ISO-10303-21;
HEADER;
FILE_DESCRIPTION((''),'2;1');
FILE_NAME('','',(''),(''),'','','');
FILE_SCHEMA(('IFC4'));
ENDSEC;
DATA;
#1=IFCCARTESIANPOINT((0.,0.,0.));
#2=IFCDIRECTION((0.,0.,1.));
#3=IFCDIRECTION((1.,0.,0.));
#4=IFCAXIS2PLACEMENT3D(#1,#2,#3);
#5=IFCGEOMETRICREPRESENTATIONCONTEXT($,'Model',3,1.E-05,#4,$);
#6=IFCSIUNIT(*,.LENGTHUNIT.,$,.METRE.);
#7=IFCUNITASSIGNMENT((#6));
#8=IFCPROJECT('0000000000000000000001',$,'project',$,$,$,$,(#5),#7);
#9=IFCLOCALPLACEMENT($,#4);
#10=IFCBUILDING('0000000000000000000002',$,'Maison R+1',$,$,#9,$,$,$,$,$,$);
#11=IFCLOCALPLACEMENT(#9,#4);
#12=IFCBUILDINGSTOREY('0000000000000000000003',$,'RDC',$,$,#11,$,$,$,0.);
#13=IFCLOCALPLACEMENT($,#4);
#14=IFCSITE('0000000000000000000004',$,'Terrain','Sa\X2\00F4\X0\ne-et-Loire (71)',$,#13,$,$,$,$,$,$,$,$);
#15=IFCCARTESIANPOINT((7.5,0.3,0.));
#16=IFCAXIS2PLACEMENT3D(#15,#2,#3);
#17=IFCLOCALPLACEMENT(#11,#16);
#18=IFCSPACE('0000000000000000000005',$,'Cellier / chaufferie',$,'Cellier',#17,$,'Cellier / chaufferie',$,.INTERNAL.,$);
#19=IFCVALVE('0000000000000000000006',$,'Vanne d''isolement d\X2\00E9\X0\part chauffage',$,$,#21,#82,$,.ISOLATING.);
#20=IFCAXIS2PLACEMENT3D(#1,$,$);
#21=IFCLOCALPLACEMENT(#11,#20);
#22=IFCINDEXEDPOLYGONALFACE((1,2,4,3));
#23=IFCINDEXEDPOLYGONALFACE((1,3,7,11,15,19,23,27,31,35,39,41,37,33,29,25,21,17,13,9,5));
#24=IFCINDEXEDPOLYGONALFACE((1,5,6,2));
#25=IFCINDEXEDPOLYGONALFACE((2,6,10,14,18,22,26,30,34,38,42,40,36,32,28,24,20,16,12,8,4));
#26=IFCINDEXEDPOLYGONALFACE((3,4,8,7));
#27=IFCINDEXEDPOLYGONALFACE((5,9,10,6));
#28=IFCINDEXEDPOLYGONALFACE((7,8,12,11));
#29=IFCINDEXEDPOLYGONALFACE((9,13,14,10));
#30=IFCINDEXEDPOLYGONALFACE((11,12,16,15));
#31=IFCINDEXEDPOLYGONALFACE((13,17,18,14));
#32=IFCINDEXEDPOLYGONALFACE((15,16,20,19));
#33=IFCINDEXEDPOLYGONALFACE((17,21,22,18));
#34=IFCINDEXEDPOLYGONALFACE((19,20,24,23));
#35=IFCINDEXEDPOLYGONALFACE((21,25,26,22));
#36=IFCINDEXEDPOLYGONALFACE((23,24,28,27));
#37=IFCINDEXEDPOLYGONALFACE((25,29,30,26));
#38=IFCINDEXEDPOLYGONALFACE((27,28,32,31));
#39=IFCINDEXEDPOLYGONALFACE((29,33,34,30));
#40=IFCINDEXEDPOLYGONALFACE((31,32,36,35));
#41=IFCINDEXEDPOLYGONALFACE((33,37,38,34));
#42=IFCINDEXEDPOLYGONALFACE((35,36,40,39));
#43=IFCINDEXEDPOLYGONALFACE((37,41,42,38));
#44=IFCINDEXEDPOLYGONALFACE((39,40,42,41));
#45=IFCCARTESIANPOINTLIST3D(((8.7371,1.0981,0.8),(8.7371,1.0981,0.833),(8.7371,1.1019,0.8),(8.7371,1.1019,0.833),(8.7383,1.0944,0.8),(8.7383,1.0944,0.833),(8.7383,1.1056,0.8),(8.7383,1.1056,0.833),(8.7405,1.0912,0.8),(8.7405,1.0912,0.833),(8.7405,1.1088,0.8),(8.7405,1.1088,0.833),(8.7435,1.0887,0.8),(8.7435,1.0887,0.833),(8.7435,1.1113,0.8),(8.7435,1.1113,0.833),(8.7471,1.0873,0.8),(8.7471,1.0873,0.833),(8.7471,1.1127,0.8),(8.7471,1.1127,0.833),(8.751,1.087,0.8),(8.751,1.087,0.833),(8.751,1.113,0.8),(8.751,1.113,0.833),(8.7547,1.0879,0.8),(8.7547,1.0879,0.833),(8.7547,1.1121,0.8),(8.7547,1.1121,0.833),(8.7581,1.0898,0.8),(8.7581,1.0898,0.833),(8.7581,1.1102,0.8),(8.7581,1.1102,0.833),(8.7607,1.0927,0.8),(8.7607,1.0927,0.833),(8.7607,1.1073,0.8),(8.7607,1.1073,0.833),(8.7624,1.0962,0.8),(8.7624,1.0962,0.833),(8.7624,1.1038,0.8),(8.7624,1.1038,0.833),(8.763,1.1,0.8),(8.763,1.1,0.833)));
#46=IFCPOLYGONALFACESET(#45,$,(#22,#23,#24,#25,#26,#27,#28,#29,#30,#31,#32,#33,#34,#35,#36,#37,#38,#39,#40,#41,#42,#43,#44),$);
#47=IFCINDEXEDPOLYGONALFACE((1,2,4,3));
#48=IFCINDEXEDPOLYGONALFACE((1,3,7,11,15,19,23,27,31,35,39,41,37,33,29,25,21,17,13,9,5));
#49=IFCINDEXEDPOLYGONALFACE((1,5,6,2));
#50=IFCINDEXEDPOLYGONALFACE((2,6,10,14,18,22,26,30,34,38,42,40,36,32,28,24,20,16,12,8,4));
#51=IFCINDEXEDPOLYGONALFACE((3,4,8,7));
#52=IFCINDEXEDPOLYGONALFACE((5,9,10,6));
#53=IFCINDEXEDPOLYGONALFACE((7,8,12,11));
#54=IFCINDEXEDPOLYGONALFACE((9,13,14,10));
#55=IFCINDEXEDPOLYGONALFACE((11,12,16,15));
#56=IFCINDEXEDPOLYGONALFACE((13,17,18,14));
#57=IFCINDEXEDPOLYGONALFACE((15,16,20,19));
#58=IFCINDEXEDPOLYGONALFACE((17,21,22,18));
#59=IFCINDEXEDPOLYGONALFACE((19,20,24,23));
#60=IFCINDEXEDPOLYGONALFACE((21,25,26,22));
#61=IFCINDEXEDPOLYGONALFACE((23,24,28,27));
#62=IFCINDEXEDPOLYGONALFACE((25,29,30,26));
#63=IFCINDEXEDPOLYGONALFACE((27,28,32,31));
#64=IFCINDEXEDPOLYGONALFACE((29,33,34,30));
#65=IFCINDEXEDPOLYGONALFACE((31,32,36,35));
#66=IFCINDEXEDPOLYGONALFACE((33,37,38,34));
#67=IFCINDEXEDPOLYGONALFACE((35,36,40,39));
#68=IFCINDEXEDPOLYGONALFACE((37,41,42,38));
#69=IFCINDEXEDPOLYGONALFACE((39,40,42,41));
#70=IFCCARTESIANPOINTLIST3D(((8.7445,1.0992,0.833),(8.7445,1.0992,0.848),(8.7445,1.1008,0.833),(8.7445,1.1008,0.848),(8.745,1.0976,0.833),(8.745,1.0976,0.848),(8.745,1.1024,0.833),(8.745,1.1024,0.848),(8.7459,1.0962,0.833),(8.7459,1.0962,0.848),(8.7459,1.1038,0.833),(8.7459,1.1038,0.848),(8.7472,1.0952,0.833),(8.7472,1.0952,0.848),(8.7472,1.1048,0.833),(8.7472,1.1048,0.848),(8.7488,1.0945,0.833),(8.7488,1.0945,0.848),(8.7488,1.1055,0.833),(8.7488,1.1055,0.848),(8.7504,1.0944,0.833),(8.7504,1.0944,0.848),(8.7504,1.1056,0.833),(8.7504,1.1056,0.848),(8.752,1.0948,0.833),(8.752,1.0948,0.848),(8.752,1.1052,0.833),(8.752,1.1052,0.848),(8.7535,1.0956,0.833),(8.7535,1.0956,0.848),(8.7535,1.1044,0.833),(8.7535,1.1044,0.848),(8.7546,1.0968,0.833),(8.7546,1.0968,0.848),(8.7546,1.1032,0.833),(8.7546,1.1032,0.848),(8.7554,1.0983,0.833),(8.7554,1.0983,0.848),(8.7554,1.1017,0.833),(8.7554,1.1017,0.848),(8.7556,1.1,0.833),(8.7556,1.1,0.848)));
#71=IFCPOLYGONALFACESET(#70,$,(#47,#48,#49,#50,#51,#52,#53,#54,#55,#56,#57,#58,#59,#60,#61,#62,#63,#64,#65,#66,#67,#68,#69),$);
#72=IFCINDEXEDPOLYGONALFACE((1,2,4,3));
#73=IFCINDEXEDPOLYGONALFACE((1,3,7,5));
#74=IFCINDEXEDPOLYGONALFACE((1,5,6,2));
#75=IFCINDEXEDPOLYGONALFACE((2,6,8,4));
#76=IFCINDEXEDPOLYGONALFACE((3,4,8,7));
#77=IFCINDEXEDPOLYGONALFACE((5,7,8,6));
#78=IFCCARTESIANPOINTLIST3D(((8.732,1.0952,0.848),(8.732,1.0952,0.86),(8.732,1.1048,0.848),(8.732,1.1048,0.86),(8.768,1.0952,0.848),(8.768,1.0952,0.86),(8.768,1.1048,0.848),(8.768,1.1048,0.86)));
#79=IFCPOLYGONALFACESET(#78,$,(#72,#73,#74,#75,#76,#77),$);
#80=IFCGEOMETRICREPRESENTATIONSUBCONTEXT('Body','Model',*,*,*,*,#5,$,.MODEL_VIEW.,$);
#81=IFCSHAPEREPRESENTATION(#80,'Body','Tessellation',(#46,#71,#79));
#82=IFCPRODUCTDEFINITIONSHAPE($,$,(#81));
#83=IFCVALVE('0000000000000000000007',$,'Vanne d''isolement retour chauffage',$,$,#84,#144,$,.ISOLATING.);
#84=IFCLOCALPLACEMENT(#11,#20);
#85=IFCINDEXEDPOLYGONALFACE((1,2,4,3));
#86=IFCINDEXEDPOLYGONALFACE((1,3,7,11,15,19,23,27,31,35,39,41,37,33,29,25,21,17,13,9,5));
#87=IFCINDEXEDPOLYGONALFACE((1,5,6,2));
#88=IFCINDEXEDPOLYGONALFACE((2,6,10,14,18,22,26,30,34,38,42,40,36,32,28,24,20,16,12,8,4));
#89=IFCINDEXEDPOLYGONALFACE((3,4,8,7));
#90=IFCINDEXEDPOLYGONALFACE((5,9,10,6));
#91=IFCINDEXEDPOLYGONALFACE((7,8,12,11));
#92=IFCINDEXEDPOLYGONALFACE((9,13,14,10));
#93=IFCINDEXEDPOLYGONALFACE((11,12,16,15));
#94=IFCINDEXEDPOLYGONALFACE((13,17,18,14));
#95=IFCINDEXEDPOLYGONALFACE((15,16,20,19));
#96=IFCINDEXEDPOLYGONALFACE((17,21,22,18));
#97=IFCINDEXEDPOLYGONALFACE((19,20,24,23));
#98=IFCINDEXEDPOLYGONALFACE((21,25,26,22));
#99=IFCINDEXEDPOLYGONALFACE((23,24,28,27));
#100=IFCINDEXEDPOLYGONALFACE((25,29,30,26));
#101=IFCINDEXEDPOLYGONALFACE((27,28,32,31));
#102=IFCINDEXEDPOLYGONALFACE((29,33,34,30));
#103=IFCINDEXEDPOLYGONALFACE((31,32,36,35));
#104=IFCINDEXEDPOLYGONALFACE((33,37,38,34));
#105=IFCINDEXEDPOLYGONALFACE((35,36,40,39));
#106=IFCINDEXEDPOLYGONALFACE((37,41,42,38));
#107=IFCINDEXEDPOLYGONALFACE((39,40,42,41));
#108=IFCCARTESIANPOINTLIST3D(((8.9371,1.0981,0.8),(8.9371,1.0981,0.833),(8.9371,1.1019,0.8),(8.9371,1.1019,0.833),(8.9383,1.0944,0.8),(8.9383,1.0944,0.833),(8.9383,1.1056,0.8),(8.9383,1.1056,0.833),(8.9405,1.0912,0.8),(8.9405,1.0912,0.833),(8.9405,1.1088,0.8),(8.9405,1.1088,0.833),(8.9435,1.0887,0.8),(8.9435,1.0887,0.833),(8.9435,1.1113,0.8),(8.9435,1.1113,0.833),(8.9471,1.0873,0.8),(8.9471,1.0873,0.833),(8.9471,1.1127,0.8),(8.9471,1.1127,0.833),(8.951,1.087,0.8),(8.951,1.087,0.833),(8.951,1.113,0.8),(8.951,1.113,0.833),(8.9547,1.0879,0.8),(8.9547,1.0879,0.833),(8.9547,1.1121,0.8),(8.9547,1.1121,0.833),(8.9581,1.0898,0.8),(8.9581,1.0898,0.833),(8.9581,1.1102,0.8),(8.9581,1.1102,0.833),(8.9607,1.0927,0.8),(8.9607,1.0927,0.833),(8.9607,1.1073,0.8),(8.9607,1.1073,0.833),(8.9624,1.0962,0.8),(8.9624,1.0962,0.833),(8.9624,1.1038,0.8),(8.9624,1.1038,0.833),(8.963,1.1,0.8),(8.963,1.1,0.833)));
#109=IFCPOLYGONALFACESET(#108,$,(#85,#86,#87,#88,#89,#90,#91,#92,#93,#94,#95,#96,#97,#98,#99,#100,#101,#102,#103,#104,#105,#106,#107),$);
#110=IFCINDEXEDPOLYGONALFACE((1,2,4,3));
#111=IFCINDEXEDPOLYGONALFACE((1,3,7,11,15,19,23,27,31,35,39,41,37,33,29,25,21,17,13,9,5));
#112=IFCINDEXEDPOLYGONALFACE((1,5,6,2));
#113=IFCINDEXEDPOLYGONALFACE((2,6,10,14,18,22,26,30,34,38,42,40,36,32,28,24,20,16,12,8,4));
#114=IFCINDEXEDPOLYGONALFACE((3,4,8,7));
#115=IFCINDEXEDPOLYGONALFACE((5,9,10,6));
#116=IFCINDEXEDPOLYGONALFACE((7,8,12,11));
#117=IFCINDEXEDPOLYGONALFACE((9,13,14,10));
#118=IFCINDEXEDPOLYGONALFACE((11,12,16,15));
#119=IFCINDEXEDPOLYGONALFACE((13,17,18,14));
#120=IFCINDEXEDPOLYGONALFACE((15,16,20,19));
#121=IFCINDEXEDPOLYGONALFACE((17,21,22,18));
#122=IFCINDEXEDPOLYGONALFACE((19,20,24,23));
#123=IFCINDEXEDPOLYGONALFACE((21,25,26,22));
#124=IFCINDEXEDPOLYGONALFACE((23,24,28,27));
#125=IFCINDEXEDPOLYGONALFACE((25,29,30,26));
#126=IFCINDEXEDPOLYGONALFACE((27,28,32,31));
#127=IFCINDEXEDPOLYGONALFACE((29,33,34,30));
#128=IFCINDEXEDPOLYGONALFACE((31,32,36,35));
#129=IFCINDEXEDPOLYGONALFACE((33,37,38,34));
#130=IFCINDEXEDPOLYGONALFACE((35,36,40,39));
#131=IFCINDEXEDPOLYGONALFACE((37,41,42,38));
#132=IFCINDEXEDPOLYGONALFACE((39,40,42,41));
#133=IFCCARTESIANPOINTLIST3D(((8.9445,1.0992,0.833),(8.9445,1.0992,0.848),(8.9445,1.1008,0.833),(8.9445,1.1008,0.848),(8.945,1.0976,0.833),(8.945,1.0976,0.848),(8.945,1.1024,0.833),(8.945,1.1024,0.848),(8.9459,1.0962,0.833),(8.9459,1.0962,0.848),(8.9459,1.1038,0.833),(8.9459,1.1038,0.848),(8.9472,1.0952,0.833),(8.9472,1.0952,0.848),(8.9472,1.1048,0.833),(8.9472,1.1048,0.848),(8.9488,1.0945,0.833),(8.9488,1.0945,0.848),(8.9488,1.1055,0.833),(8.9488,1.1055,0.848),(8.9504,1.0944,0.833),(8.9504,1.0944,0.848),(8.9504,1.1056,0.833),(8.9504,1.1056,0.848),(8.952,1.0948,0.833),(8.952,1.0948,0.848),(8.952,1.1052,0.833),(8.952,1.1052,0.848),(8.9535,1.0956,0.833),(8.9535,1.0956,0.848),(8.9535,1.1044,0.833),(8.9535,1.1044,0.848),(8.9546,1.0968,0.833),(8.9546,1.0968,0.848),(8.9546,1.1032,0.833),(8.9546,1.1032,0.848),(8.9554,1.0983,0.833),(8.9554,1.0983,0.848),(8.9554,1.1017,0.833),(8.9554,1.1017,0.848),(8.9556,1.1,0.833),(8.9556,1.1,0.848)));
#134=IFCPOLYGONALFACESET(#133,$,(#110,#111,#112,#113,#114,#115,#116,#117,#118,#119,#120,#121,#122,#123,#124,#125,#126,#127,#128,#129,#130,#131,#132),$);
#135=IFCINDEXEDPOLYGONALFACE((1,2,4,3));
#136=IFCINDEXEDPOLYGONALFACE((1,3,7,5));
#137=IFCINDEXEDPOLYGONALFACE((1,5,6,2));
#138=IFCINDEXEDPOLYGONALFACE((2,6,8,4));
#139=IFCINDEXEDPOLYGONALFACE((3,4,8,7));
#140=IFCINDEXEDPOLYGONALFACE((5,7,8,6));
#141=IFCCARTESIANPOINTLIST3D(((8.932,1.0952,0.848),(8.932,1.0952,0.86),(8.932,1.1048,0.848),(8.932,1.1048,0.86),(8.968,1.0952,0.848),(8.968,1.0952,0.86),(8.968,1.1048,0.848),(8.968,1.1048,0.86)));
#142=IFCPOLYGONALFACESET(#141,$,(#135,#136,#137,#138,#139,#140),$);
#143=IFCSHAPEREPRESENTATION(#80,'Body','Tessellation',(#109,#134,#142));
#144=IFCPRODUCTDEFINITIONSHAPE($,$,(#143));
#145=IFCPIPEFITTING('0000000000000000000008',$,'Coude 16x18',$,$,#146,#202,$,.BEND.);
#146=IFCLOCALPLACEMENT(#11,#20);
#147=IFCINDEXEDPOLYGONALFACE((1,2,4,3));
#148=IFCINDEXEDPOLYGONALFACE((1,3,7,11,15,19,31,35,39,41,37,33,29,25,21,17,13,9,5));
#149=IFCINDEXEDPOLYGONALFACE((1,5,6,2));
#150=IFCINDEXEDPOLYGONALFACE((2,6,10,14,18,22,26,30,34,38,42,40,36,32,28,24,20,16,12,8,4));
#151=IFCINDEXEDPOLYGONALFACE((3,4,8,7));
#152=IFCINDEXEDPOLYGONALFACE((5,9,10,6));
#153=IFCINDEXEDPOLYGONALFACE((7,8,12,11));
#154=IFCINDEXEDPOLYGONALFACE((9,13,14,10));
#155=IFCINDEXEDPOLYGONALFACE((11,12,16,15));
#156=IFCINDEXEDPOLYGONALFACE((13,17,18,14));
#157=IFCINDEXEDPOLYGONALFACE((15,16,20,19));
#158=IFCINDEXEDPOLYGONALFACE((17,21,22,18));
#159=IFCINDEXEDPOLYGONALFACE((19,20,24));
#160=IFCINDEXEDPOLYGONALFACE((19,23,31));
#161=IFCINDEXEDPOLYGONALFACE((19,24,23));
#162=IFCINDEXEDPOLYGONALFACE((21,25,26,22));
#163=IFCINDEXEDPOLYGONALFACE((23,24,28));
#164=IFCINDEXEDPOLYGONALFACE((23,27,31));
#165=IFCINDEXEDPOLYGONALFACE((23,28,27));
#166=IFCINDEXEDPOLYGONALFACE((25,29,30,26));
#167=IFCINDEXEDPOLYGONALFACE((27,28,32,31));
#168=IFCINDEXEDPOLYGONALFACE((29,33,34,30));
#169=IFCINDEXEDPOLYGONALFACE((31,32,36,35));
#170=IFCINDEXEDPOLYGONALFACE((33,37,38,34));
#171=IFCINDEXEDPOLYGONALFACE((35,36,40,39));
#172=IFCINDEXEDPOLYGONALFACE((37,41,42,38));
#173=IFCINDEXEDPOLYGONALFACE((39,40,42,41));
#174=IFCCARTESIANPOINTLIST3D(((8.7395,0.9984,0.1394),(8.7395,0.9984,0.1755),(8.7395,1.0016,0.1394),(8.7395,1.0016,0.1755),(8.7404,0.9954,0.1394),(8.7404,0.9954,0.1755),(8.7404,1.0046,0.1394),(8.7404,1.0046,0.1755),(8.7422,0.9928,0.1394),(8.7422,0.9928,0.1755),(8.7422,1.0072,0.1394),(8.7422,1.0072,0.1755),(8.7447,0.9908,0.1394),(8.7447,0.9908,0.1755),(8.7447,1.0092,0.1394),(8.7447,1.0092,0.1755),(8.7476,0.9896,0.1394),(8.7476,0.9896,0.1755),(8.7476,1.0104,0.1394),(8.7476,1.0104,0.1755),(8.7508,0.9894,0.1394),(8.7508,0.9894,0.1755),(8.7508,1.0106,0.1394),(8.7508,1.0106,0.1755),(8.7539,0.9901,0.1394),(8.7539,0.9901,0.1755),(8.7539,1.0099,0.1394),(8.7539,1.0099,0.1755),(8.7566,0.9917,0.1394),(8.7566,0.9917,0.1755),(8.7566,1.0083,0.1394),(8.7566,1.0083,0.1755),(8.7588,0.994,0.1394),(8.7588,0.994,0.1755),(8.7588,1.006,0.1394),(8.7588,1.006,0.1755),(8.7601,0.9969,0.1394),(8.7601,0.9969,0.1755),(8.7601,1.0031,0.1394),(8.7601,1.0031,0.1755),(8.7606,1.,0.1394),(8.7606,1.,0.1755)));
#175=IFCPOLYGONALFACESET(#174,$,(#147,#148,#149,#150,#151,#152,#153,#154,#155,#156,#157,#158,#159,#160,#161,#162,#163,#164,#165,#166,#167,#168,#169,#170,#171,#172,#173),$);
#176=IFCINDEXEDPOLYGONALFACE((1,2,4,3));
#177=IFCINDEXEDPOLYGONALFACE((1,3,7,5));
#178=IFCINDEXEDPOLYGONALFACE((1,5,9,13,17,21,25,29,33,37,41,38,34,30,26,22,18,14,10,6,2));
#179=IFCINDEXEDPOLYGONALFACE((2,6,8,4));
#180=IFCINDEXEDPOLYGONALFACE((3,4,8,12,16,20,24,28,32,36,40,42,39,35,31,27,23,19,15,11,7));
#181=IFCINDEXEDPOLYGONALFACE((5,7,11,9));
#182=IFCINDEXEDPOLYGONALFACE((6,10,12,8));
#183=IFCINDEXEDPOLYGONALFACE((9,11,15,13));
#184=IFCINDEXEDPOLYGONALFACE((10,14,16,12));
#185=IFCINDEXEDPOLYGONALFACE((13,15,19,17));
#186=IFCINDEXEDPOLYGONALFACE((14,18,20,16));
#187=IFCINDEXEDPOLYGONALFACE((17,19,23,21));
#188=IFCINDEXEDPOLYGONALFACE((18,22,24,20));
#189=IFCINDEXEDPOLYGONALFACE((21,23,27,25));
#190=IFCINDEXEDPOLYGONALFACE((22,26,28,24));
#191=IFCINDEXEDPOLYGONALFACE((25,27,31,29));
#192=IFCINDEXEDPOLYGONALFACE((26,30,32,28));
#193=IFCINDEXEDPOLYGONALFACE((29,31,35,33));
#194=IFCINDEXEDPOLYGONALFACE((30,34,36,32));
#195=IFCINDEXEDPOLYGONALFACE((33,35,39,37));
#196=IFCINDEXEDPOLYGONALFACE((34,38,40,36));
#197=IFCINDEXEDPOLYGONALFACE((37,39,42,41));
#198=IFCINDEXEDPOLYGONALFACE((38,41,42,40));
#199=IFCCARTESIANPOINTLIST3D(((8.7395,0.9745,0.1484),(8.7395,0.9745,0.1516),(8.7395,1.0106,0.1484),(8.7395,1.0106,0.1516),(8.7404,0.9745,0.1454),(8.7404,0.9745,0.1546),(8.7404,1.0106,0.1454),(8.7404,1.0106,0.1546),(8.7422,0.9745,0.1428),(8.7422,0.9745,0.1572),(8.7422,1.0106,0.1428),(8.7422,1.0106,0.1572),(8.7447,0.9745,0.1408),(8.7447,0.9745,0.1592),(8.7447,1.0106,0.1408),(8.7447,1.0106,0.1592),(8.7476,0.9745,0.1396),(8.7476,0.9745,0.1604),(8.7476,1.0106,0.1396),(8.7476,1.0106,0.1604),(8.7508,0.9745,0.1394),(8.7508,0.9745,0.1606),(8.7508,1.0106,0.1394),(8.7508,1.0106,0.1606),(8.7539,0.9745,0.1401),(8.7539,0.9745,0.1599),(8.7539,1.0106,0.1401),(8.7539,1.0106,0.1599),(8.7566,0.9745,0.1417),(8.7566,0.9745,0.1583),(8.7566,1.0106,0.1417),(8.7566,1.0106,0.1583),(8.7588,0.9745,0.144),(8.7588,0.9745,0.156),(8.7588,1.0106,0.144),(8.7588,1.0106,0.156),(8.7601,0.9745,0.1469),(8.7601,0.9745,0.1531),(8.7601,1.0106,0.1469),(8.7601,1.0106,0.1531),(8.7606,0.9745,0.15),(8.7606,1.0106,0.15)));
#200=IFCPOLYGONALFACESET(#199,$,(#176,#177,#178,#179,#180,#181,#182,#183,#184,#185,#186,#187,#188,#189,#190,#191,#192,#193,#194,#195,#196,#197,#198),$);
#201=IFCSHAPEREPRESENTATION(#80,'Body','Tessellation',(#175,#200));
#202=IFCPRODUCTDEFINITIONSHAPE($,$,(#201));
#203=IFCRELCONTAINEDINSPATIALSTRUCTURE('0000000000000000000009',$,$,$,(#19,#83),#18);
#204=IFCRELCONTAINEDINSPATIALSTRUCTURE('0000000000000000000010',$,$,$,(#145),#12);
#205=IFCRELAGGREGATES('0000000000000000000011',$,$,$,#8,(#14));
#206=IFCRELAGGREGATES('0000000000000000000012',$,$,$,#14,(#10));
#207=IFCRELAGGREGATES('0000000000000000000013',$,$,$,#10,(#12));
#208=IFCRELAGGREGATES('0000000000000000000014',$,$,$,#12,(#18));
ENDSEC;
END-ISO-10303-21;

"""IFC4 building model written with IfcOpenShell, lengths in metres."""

from ifc_helpers import new_model, si_unit, frame, frame_2d, origin_with_axes, place, context, subcontext, project, spatial, rectangle, circle, extrude, element, save


model = new_model("IFC4")

# Units and contexts
model_context = context("Model", 3, precision=1e-05, world=origin_with_axes())
body_context = subcontext(model_context, "Body", "Model", "MODEL_VIEW")
ifc_project = project(units=[si_unit("LENGTHUNIT", "METRE")], contexts=[model_context])

# Site, building, storey
site_placement = place(None, origin_with_axes())
site = spatial("IfcSite", under=ifc_project, at=site_placement, Name="Terrain", Description="Saône-et-Loire (71)")
building_placement = place(None, origin_with_axes())
building = spatial("IfcBuilding", under=site, at=building_placement, Name="Maison R+1")
storey_placement = place(building_placement, origin_with_axes())
storey = spatial("IfcBuildingStorey", under=building, at=storey_placement, Name="RDC", Elevation=0.0)

# Shared definitions
space_placement = place(storey_placement, frame((7.5, 0.3, 0.0), z_axis=(0.0, 0.0, 1.0), x_axis=(1.0, 0.0, 0.0)))
space = spatial("IfcSpace", under=storey, at=space_placement, Name="Cellier / chaufferie", ObjectType="Cellier", LongName="Cellier / chaufferie", PredefinedType="INTERNAL")

# Valves
for number, where, z_axis, x_axis, name in (
    (1, (1.25, 0.8, 0.8), (0.0, 0.0, 1.0), (1.0, 0.0, 0.0), "Vanne d'isolement départ chauffage"),
    (2, (1.45, 0.8, 0.8), (0.0, 0.0, 1.0), (1.0, 0.0, 0.0), "Vanne d'isolement retour chauffage"),
):
    element("IfcValve", number, at=place(space_placement, frame(where, z_axis=z_axis, x_axis=x_axis)), inside=space, Name=name, PredefinedType="ISOLATING", context=body_context, shape_type="SweptSolid", body=[
        extrude(circle(Radius=0.013), origin_with_axes(), (0.0, 0.0, 1.0), 0.033),
        extrude(circle(Radius=0.0056), frame((0.0, 0.0, 0.033), z_axis=(0.0, 0.0, 1.0), x_axis=(1.0, 0.0, 0.0)), (0.0, 0.0, 1.0), 0.015),
        extrude(rectangle(XDim=0.036, YDim=0.0096, at=frame_2d((0.018, 0.0048))), frame((-0.018, -0.0048, 0.048), z_axis=(0.0, 0.0, 1.0), x_axis=(1.0, 0.0, 0.0)), (0.0, 0.0, 1.0), 0.012),
    ])

# Pipe fitting
pipe_fitting_1_placement = place(storey_placement, frame((8.75, 1.0, 0.15), z_axis=(0.0, 0.0, 1.0), x_axis=(1.0, 0.0, 0.0)))
element("IfcPipeFitting", 3, at=pipe_fitting_1_placement, inside=storey, Name="Coude 16x18", PredefinedType="BEND", context=body_context, shape_type="SweptSolid", body=[
    extrude(circle(Radius=0.0106), frame((0.0, 0.0, -0.0106), z_axis=(0.0, 0.0, 1.0), x_axis=(1.0, 0.0, 0.0)), (0.0, 0.0, 1.0), 0.0361),
    extrude(circle(Radius=0.0106), frame((0.0, 0.0106, 0.0), z_axis=(0.0, -1.0, 0.0), x_axis=(1.0, 0.0, 0.0)), (0.0, 0.0, 1.0), 0.0361),
])

save(model, "model.ifc")
